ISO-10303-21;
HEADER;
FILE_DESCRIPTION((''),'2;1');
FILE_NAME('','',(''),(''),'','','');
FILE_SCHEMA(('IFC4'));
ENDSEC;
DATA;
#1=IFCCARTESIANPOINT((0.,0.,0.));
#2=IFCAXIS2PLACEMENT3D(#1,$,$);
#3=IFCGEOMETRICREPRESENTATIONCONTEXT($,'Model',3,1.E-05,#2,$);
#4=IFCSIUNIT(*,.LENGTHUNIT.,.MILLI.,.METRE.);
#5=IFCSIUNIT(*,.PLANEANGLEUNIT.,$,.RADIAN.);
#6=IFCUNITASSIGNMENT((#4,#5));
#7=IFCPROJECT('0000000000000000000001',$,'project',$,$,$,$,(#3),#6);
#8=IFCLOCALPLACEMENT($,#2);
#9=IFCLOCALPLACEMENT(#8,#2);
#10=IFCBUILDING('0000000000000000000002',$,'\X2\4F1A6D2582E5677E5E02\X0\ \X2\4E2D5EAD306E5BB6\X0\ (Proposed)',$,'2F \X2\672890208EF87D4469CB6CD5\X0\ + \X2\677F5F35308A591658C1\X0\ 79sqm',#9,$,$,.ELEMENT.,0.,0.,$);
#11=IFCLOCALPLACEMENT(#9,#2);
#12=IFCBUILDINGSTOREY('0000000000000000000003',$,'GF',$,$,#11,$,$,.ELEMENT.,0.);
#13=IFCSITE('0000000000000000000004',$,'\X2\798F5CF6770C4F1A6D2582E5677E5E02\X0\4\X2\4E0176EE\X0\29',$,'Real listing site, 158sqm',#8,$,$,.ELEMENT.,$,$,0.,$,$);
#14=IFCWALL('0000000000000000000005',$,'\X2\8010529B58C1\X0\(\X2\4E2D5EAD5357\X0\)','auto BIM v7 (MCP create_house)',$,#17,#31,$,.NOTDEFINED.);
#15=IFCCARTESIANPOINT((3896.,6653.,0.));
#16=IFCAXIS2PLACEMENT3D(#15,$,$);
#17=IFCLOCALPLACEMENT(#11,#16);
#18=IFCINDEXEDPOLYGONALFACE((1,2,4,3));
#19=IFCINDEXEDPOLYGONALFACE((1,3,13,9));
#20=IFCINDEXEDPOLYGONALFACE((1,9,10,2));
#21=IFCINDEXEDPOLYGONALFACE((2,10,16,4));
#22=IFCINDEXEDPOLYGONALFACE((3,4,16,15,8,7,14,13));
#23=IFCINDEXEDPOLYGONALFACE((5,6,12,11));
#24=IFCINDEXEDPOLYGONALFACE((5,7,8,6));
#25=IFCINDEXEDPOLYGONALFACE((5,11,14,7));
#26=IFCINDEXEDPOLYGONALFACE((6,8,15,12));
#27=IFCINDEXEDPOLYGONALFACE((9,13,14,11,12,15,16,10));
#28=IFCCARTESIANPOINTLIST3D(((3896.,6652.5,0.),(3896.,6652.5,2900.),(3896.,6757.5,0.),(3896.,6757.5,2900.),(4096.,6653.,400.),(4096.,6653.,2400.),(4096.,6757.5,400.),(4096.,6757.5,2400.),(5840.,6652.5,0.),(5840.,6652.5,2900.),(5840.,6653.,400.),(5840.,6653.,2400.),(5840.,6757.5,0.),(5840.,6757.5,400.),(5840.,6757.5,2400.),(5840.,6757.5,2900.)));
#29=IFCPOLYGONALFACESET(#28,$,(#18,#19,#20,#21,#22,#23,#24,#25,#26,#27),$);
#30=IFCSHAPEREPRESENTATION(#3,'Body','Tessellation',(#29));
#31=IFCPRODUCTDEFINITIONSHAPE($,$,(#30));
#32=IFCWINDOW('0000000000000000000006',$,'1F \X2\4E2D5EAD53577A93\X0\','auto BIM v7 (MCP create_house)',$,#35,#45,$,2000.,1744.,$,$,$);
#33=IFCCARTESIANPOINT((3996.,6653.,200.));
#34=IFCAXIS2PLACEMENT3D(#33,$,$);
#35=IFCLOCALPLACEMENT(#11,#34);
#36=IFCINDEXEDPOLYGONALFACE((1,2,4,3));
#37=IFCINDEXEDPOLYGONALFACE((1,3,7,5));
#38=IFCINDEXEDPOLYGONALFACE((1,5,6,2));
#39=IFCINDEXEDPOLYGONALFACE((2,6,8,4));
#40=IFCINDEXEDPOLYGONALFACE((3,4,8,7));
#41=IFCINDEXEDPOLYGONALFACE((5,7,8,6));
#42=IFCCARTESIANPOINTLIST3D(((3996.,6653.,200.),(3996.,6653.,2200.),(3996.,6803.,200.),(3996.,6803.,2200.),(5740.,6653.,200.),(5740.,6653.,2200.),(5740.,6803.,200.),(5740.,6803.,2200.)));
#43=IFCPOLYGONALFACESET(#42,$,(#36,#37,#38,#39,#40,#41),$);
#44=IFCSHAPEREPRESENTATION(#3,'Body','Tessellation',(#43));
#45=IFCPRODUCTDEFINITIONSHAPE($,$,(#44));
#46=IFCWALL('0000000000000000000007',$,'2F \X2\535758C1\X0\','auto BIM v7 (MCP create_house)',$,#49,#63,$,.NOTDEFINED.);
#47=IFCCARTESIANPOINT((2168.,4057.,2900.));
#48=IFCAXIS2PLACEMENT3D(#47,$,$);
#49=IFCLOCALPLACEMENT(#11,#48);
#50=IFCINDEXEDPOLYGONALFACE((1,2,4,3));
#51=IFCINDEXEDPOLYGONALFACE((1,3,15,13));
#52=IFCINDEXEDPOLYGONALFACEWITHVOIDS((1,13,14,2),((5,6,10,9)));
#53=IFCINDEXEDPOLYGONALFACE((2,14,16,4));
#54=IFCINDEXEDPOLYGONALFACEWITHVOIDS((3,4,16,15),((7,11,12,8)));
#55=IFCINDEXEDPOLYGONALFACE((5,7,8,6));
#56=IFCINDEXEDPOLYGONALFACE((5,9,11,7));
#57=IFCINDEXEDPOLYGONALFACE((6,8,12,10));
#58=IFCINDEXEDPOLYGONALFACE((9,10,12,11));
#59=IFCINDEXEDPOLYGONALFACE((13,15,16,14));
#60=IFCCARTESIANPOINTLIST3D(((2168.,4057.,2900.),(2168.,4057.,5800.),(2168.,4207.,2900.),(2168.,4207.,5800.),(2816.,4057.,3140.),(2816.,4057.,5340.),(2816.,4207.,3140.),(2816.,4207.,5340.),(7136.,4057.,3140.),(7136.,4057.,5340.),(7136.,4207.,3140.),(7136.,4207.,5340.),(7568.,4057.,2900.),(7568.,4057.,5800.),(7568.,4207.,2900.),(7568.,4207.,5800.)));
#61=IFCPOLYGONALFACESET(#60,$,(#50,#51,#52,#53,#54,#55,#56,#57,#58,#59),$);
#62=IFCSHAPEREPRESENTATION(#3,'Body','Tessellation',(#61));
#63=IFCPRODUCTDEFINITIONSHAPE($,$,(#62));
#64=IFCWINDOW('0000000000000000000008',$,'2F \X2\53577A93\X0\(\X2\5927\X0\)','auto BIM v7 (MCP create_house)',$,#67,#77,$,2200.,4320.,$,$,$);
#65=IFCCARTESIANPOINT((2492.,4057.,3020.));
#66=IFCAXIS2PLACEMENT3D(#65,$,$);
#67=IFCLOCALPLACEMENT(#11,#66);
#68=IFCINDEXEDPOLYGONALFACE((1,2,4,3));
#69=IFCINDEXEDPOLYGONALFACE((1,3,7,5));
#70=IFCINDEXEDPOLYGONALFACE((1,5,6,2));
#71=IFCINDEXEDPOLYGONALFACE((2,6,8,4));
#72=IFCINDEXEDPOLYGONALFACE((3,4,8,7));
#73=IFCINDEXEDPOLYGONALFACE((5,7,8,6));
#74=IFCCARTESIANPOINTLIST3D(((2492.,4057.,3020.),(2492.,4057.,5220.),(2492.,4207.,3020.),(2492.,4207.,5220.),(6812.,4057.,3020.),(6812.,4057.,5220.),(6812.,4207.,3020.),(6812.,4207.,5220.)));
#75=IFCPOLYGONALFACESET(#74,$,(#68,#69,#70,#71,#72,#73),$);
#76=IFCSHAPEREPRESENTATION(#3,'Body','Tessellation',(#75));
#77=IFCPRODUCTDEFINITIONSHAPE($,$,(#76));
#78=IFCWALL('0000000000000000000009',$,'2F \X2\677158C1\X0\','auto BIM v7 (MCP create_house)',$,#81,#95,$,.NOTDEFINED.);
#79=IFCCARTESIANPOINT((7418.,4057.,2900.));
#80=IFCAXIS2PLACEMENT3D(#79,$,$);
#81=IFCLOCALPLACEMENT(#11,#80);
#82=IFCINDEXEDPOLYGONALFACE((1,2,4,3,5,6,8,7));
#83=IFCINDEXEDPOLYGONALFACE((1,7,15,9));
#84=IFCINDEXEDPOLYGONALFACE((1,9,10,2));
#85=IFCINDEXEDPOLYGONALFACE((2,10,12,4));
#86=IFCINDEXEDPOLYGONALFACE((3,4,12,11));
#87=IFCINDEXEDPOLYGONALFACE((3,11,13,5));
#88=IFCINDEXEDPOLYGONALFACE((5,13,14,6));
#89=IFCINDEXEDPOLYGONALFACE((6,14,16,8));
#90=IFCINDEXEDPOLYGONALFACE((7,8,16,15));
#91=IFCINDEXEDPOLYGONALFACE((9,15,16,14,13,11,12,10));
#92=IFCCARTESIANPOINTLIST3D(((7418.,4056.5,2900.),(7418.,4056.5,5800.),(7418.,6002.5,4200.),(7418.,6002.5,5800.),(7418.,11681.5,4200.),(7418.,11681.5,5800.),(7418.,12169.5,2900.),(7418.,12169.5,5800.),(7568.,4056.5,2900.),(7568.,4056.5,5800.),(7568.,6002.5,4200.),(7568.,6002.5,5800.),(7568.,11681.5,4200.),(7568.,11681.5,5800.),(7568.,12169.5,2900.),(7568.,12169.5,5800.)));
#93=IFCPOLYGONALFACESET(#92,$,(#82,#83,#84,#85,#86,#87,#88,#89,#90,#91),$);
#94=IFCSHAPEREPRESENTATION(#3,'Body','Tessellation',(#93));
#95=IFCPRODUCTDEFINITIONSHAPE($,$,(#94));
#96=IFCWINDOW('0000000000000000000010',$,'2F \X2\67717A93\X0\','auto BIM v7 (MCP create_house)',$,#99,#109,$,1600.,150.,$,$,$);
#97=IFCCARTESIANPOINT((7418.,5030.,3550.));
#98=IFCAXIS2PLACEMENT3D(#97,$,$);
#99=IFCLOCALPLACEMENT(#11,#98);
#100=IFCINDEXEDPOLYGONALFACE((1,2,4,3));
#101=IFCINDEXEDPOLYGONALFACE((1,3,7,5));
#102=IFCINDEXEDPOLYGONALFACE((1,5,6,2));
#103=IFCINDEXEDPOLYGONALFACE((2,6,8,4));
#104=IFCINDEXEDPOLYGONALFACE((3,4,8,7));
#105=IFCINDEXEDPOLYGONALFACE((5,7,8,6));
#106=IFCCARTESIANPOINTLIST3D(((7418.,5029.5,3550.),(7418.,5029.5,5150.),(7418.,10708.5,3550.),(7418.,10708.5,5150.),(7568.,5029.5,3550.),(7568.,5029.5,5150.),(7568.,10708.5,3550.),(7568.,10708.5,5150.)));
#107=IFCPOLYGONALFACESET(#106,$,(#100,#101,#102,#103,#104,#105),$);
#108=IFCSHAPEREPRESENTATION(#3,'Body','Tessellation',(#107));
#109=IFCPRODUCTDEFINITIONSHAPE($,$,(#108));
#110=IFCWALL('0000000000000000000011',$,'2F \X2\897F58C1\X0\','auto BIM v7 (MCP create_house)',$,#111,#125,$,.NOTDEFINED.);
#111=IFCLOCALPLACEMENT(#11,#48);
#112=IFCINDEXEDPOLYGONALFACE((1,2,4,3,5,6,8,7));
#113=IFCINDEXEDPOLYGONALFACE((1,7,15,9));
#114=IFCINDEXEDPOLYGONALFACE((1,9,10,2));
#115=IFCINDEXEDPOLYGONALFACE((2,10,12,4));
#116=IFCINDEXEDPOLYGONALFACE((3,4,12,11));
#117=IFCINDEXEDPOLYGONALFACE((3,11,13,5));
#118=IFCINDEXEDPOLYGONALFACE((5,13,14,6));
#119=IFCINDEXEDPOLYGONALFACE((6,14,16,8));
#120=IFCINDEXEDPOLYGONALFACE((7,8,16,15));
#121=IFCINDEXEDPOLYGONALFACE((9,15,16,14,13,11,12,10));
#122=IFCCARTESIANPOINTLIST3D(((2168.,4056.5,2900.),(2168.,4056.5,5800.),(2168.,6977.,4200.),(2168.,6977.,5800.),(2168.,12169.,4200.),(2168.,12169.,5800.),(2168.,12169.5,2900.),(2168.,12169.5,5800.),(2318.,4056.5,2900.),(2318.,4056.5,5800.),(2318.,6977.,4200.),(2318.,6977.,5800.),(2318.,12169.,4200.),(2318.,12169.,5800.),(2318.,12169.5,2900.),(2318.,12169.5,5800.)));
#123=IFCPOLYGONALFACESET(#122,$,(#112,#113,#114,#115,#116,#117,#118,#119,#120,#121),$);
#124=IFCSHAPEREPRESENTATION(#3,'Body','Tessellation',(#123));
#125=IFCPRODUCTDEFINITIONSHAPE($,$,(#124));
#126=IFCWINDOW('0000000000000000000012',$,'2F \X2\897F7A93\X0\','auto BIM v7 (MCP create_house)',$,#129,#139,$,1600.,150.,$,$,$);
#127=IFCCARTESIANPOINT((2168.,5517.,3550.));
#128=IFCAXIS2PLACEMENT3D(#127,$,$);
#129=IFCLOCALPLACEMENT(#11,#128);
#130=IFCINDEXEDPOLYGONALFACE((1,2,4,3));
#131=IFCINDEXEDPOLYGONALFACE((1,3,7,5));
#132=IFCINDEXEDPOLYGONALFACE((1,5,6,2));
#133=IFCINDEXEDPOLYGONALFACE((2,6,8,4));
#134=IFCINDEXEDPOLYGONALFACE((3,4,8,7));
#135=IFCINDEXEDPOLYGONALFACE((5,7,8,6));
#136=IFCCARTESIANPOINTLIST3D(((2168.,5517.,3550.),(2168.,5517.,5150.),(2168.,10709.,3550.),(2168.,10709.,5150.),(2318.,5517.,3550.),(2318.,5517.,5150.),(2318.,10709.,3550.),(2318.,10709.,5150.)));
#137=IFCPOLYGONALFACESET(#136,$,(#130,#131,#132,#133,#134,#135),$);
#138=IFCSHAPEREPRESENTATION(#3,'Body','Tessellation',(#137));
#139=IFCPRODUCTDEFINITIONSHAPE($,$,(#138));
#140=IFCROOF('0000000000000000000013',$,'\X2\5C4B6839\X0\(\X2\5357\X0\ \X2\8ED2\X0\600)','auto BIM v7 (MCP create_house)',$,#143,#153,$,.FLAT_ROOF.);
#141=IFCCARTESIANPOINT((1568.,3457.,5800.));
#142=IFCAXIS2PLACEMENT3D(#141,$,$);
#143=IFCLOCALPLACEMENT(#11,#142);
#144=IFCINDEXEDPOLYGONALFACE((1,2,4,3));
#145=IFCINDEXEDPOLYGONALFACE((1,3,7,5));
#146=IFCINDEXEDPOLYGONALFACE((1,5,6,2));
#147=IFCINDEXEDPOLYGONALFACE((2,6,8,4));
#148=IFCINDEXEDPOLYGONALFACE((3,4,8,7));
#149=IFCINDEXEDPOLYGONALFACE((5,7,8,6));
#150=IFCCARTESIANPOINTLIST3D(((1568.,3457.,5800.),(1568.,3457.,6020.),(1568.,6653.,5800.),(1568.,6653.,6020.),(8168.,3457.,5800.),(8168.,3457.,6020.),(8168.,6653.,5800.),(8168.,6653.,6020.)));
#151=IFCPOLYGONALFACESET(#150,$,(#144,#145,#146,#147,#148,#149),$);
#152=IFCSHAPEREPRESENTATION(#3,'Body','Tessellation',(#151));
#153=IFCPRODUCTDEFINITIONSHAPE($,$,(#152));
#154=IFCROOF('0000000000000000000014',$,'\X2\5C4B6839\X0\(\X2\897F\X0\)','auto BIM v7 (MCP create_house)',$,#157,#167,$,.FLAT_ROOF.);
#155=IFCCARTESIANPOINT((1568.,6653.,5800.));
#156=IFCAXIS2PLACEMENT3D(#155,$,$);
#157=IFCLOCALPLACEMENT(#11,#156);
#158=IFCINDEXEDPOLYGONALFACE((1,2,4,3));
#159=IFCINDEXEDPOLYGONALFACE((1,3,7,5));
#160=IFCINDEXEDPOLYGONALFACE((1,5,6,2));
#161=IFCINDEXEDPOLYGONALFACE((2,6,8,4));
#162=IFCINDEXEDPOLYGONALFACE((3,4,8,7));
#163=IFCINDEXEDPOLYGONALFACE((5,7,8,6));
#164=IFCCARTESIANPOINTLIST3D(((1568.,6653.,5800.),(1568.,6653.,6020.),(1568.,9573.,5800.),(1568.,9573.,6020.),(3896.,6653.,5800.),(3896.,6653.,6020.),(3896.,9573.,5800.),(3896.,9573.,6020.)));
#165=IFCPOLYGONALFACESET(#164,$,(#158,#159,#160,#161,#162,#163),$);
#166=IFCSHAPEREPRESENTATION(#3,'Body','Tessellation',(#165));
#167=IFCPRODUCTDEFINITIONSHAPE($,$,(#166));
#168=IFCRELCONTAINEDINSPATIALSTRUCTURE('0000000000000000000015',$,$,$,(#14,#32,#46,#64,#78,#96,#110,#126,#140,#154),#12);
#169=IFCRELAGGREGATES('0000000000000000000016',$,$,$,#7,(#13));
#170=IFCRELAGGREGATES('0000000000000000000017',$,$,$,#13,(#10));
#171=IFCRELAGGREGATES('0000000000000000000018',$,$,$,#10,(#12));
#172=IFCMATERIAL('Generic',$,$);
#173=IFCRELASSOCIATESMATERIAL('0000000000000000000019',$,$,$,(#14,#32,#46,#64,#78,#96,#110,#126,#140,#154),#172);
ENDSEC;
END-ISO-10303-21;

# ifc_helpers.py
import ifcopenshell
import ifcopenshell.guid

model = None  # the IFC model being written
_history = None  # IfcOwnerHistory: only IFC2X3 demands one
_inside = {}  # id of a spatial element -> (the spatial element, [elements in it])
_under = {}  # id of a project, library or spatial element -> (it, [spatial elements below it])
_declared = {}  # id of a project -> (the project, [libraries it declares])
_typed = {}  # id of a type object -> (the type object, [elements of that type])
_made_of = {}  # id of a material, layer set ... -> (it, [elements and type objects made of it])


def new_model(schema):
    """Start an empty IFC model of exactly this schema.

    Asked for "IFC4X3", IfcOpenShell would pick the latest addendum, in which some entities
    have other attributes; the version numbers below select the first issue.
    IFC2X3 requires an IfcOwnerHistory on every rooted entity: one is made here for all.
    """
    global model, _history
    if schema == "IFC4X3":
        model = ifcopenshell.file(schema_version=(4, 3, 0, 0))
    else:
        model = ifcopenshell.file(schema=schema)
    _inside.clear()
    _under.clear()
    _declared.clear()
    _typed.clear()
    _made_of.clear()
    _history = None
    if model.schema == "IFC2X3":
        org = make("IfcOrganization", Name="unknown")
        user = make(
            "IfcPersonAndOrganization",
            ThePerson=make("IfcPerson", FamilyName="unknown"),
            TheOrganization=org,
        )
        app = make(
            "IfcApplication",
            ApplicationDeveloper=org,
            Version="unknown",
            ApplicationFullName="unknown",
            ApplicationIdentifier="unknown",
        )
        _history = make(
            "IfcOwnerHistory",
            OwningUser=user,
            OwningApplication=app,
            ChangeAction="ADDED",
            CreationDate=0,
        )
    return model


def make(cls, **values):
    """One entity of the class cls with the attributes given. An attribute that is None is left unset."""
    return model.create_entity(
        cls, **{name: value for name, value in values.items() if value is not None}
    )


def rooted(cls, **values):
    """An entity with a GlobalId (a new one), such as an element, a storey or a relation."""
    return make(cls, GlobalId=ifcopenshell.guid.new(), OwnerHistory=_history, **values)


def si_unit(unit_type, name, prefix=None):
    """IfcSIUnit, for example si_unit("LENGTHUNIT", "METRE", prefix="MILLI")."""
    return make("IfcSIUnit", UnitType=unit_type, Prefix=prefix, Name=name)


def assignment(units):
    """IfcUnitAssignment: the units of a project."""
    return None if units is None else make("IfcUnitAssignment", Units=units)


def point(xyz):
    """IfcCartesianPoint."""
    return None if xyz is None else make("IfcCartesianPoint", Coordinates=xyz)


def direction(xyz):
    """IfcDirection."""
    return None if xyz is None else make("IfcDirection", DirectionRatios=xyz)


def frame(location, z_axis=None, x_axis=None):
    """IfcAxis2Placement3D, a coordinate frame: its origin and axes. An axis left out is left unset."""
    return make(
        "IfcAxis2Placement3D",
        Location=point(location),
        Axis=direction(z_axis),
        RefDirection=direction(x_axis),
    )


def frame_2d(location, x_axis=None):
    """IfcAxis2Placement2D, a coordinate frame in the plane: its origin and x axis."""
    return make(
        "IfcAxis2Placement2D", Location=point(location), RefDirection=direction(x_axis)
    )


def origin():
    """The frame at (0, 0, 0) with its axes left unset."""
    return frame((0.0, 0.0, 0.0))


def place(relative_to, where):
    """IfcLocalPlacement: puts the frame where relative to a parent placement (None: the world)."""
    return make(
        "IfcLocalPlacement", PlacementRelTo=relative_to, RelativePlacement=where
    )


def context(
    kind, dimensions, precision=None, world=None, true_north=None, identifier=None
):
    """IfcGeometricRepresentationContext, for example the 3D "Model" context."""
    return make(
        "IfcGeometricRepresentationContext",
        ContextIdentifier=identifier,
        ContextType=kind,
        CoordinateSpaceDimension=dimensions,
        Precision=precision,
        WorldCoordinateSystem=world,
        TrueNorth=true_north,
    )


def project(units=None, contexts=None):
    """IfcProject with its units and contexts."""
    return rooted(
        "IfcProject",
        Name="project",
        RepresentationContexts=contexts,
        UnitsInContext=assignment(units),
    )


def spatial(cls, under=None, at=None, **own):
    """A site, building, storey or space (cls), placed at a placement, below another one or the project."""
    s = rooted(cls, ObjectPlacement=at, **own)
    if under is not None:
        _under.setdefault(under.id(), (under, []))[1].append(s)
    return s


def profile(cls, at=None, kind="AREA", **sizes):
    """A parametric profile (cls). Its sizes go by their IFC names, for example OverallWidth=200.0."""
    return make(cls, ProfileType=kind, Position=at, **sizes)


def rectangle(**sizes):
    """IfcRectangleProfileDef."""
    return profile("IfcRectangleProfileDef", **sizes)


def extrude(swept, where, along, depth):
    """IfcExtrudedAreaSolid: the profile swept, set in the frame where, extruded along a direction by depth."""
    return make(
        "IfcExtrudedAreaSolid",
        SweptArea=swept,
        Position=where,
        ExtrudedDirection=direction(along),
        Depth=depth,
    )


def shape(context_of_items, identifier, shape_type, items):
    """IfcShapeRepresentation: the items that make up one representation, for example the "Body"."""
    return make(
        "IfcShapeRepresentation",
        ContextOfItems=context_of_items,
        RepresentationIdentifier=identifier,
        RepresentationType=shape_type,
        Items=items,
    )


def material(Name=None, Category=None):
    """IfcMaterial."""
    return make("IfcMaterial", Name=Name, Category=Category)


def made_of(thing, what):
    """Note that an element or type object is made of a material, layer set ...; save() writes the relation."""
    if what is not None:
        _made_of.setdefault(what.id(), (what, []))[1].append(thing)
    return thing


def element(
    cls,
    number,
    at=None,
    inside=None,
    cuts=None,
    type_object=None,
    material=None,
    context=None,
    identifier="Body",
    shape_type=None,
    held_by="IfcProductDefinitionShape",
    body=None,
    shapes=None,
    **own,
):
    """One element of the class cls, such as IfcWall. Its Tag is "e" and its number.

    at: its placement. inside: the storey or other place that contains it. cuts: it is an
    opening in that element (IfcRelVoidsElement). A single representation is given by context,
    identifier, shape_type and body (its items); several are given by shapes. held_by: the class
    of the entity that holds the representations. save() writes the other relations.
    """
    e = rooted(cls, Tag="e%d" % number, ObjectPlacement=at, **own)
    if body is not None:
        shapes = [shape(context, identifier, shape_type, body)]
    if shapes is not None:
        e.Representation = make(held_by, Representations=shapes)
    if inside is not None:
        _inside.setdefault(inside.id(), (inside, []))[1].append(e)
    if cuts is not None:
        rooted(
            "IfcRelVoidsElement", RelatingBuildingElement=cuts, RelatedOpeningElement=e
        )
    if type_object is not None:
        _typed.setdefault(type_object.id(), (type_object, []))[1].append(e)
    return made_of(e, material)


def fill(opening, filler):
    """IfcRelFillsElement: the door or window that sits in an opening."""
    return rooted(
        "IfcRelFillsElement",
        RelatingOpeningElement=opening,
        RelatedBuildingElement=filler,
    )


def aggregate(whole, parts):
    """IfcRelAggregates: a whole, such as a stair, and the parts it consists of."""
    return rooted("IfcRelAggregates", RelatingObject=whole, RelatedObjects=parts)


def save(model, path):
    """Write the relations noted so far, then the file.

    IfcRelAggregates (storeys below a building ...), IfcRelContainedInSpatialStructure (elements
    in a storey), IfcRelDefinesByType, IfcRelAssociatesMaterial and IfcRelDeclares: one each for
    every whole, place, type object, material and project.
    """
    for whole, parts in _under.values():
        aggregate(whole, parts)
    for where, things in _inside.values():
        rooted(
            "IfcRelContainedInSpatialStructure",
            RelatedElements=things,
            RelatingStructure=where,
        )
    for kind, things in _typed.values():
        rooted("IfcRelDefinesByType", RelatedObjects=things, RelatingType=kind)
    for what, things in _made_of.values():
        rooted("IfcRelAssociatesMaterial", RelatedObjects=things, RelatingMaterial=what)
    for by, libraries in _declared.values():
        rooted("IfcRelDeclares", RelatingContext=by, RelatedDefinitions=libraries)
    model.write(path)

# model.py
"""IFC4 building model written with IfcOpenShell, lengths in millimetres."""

from ifc_helpers import new_model, si_unit, frame, frame_2d, origin, place, context, project, spatial, rectangle, extrude, material, element, fill, save


model = new_model("IFC4")

# Units and contexts
model_context = context("Model", 3, precision=1e-05, world=origin())
ifc_project = project(units=[si_unit("LENGTHUNIT", "METRE", prefix="MILLI"), si_unit("PLANEANGLEUNIT", "RADIAN")], contexts=[model_context])

# Site, building, storey
site_placement = place(None, origin())
site = spatial("IfcSite", under=ifc_project, at=site_placement, Name="福島県会津若松市4丁目29", ObjectType="Real listing site, 158sqm", CompositionType="ELEMENT", RefElevation=0.0)
building_placement = place(site_placement, origin())
building = spatial("IfcBuilding", under=site, at=building_placement, Name="会津若松市 中庭の家 (Proposed)", ObjectType="2F 木造軸組構法 + 板張り外壁 79sqm", CompositionType="ELEMENT", ElevationOfRefHeight=0.0, ElevationOfTerrain=0.0)
storey_placement = place(building_placement, origin())
storey = spatial("IfcBuildingStorey", under=building, at=storey_placement, Name="GF", CompositionType="ELEMENT", Elevation=0.0)

# Shared definitions
ifc_material = material(Name="Generic")

# Wall, opening, window
wall_1_placement = place(storey_placement, frame((3896.0, 6653.0, 0.0)))
wall_1 = element("IfcWall", 1, at=wall_1_placement, inside=storey, material=ifc_material, Name="耐力壁(中庭南)", Description="auto BIM v7 (MCP create_house)", PredefinedType="NOTDEFINED", context=model_context, shape_type="SweptSolid", body=[
    extrude(rectangle(XDim=1944.0, YDim=105.0, at=frame_2d((972.0, 52.0))), frame((3896.0, 6653.0, 0.0)), (0.0, 0.0, 1.0), 2900.0),
])
opening_1_placement = place(storey_placement, frame((3996.0, 6653.0, 200.0)))
opening_1 = element("IfcOpeningElement", 2, at=opening_1_placement, cuts=wall_1, PredefinedType="NOTDEFINED", context=model_context, shape_type="SweptSolid", body=[
    extrude(rectangle(XDim=1744.0, YDim=150.0, at=frame_2d((872.0, 75.0))), frame((3996.0, 6653.0, 200.0)), (0.0, 0.0, 1.0), 2000.0),
])
window_1_placement = place(storey_placement, frame((3996.0, 6653.0, 200.0)))
window_1 = element("IfcWindow", 3, at=window_1_placement, inside=storey, material=ifc_material, Name="1F 中庭南窓", Description="auto BIM v7 (MCP create_house)", OverallHeight=2000.0, OverallWidth=1744.0, context=model_context, shape_type="SweptSolid", body=[
    extrude(rectangle(XDim=1744.0, YDim=150.0, at=frame_2d((872.0, 75.0))), frame((3996.0, 6653.0, 200.0)), (0.0, 0.0, 1.0), 2000.0),
])
fill(opening_1, window_1)

# Walls, openings, windows
wall_2_placement = place(storey_placement, frame((2168.0, 4057.0, 2900.0)))
wall_2 = element("IfcWall", 4, at=wall_2_placement, inside=storey, material=ifc_material, Name="2F 南壁", Description="auto BIM v7 (MCP create_house)", PredefinedType="NOTDEFINED", context=model_context, shape_type="SweptSolid", body=[
    extrude(rectangle(XDim=5400.0, YDim=150.0, at=frame_2d((2700.0, 75.0))), frame((2168.0, 4057.0, 2900.0)), (0.0, 0.0, 1.0), 2900.0),
])
opening_2_placement = place(storey_placement, frame((2492.0, 4057.0, 3020.0)))
opening_2 = element("IfcOpeningElement", 5, at=opening_2_placement, cuts=wall_2, PredefinedType="NOTDEFINED", context=model_context, shape_type="SweptSolid", body=[
    extrude(rectangle(XDim=4320.0, YDim=150.0, at=frame_2d((2160.0, 75.0))), frame((2492.0, 4057.0, 3020.0)), (0.0, 0.0, 1.0), 2200.0),
])
window_2_placement = place(storey_placement, frame((2492.0, 4057.0, 3020.0)))
window_2 = element("IfcWindow", 6, at=window_2_placement, inside=storey, material=ifc_material, Name="2F 南窓(大)", Description="auto BIM v7 (MCP create_house)", OverallHeight=2200.0, OverallWidth=4320.0, context=model_context, shape_type="SweptSolid", body=[
    extrude(rectangle(XDim=4320.0, YDim=150.0, at=frame_2d((2160.0, 75.0))), frame((2492.0, 4057.0, 3020.0)), (0.0, 0.0, 1.0), 2200.0),
])
fill(opening_2, window_2)
wall_3_placement = place(storey_placement, frame((7418.0, 4057.0, 2900.0)))
wall_3 = element("IfcWall", 7, at=wall_3_placement, inside=storey, material=ifc_material, Name="2F 東壁", Description="auto BIM v7 (MCP create_house)", PredefinedType="NOTDEFINED", context=model_context, shape_type="SweptSolid", body=[
    extrude(rectangle(XDim=150.0, YDim=8113.0, at=frame_2d((75.0, 4056.0))), frame((7418.0, 4057.0, 2900.0)), (0.0, 0.0, 1.0), 2900.0),
])
opening_3_placement = place(storey_placement, frame((7418.0, 5030.0, 3550.0)))
opening_3 = element("IfcOpeningElement", 8, at=opening_3_placement, cuts=wall_3, PredefinedType="NOTDEFINED", context=model_context, shape_type="SweptSolid", body=[
    extrude(rectangle(XDim=150.0, YDim=5679.0, at=frame_2d((75.0, 2839.0))), frame((7418.0, 5030.0, 3550.0)), (0.0, 0.0, 1.0), 1600.0),
])
window_3_placement = place(storey_placement, frame((7418.0, 5030.0, 3550.0)))
window_3 = element("IfcWindow", 9, at=window_3_placement, inside=storey, material=ifc_material, Name="2F 東窓", Description="auto BIM v7 (MCP create_house)", OverallHeight=1600.0, OverallWidth=150.0, context=model_context, shape_type="SweptSolid", body=[
    extrude(rectangle(XDim=150.0, YDim=5679.0, at=frame_2d((75.0, 2839.0))), frame((7418.0, 5030.0, 3550.0)), (0.0, 0.0, 1.0), 1600.0),
])
fill(opening_3, window_3)
wall_4_placement = place(storey_placement, frame((2168.0, 4057.0, 2900.0)))
wall_4 = element("IfcWall", 10, at=wall_4_placement, inside=storey, material=ifc_material, Name="2F 西壁", Description="auto BIM v7 (MCP create_house)", PredefinedType="NOTDEFINED", context=model_context, shape_type="SweptSolid", body=[
    extrude(rectangle(XDim=150.0, YDim=8113.0, at=frame_2d((75.0, 4056.0))), frame((2168.0, 4057.0, 2900.0)), (0.0, 0.0, 1.0), 2900.0),
])
opening_4_placement = place(storey_placement, frame((2168.0, 5517.0, 3550.0)))
opening_4 = element("IfcOpeningElement", 11, at=opening_4_placement, cuts=wall_4, PredefinedType="NOTDEFINED", context=model_context, shape_type="SweptSolid", body=[
    extrude(rectangle(XDim=150.0, YDim=5192.0, at=frame_2d((75.0, 2596.0))), frame((2168.0, 5517.0, 3550.0)), (0.0, 0.0, 1.0), 1600.0),
])
window_4_placement = place(storey_placement, frame((2168.0, 5517.0, 3550.0)))
window_4 = element("IfcWindow", 12, at=window_4_placement, inside=storey, material=ifc_material, Name="2F 西窓", Description="auto BIM v7 (MCP create_house)", OverallHeight=1600.0, OverallWidth=150.0, context=model_context, shape_type="SweptSolid", body=[
    extrude(rectangle(XDim=150.0, YDim=5192.0, at=frame_2d((75.0, 2596.0))), frame((2168.0, 5517.0, 3550.0)), (0.0, 0.0, 1.0), 1600.0),
])
fill(opening_4, window_4)

# Roofs
roof_1_placement = place(storey_placement, frame((1568.0, 3457.0, 5800.0)))
element("IfcRoof", 13, at=roof_1_placement, inside=storey, material=ifc_material, Name="屋根(南 軒600)", Description="auto BIM v7 (MCP create_house)", PredefinedType="FLAT_ROOF", context=model_context, shape_type="SweptSolid", body=[
    extrude(rectangle(XDim=6600.0, YDim=3196.0, at=frame_2d((3300.0, 1598.0))), frame((1568.0, 3457.0, 5800.0)), (0.0, 0.0, 1.0), 220.0),
])
roof_2_placement = place(storey_placement, frame((1568.0, 6653.0, 5800.0)))
element("IfcRoof", 14, at=roof_2_placement, inside=storey, material=ifc_material, Name="屋根(西)", Description="auto BIM v7 (MCP create_house)", PredefinedType="FLAT_ROOF", context=model_context, shape_type="SweptSolid", body=[
    extrude(rectangle(XDim=2328.0, YDim=2920.0, at=frame_2d((1164.0, 1460.0))), frame((1568.0, 6653.0, 5800.0)), (0.0, 0.0, 1.0), 220.0),
])

save(model, "model.ifc")
